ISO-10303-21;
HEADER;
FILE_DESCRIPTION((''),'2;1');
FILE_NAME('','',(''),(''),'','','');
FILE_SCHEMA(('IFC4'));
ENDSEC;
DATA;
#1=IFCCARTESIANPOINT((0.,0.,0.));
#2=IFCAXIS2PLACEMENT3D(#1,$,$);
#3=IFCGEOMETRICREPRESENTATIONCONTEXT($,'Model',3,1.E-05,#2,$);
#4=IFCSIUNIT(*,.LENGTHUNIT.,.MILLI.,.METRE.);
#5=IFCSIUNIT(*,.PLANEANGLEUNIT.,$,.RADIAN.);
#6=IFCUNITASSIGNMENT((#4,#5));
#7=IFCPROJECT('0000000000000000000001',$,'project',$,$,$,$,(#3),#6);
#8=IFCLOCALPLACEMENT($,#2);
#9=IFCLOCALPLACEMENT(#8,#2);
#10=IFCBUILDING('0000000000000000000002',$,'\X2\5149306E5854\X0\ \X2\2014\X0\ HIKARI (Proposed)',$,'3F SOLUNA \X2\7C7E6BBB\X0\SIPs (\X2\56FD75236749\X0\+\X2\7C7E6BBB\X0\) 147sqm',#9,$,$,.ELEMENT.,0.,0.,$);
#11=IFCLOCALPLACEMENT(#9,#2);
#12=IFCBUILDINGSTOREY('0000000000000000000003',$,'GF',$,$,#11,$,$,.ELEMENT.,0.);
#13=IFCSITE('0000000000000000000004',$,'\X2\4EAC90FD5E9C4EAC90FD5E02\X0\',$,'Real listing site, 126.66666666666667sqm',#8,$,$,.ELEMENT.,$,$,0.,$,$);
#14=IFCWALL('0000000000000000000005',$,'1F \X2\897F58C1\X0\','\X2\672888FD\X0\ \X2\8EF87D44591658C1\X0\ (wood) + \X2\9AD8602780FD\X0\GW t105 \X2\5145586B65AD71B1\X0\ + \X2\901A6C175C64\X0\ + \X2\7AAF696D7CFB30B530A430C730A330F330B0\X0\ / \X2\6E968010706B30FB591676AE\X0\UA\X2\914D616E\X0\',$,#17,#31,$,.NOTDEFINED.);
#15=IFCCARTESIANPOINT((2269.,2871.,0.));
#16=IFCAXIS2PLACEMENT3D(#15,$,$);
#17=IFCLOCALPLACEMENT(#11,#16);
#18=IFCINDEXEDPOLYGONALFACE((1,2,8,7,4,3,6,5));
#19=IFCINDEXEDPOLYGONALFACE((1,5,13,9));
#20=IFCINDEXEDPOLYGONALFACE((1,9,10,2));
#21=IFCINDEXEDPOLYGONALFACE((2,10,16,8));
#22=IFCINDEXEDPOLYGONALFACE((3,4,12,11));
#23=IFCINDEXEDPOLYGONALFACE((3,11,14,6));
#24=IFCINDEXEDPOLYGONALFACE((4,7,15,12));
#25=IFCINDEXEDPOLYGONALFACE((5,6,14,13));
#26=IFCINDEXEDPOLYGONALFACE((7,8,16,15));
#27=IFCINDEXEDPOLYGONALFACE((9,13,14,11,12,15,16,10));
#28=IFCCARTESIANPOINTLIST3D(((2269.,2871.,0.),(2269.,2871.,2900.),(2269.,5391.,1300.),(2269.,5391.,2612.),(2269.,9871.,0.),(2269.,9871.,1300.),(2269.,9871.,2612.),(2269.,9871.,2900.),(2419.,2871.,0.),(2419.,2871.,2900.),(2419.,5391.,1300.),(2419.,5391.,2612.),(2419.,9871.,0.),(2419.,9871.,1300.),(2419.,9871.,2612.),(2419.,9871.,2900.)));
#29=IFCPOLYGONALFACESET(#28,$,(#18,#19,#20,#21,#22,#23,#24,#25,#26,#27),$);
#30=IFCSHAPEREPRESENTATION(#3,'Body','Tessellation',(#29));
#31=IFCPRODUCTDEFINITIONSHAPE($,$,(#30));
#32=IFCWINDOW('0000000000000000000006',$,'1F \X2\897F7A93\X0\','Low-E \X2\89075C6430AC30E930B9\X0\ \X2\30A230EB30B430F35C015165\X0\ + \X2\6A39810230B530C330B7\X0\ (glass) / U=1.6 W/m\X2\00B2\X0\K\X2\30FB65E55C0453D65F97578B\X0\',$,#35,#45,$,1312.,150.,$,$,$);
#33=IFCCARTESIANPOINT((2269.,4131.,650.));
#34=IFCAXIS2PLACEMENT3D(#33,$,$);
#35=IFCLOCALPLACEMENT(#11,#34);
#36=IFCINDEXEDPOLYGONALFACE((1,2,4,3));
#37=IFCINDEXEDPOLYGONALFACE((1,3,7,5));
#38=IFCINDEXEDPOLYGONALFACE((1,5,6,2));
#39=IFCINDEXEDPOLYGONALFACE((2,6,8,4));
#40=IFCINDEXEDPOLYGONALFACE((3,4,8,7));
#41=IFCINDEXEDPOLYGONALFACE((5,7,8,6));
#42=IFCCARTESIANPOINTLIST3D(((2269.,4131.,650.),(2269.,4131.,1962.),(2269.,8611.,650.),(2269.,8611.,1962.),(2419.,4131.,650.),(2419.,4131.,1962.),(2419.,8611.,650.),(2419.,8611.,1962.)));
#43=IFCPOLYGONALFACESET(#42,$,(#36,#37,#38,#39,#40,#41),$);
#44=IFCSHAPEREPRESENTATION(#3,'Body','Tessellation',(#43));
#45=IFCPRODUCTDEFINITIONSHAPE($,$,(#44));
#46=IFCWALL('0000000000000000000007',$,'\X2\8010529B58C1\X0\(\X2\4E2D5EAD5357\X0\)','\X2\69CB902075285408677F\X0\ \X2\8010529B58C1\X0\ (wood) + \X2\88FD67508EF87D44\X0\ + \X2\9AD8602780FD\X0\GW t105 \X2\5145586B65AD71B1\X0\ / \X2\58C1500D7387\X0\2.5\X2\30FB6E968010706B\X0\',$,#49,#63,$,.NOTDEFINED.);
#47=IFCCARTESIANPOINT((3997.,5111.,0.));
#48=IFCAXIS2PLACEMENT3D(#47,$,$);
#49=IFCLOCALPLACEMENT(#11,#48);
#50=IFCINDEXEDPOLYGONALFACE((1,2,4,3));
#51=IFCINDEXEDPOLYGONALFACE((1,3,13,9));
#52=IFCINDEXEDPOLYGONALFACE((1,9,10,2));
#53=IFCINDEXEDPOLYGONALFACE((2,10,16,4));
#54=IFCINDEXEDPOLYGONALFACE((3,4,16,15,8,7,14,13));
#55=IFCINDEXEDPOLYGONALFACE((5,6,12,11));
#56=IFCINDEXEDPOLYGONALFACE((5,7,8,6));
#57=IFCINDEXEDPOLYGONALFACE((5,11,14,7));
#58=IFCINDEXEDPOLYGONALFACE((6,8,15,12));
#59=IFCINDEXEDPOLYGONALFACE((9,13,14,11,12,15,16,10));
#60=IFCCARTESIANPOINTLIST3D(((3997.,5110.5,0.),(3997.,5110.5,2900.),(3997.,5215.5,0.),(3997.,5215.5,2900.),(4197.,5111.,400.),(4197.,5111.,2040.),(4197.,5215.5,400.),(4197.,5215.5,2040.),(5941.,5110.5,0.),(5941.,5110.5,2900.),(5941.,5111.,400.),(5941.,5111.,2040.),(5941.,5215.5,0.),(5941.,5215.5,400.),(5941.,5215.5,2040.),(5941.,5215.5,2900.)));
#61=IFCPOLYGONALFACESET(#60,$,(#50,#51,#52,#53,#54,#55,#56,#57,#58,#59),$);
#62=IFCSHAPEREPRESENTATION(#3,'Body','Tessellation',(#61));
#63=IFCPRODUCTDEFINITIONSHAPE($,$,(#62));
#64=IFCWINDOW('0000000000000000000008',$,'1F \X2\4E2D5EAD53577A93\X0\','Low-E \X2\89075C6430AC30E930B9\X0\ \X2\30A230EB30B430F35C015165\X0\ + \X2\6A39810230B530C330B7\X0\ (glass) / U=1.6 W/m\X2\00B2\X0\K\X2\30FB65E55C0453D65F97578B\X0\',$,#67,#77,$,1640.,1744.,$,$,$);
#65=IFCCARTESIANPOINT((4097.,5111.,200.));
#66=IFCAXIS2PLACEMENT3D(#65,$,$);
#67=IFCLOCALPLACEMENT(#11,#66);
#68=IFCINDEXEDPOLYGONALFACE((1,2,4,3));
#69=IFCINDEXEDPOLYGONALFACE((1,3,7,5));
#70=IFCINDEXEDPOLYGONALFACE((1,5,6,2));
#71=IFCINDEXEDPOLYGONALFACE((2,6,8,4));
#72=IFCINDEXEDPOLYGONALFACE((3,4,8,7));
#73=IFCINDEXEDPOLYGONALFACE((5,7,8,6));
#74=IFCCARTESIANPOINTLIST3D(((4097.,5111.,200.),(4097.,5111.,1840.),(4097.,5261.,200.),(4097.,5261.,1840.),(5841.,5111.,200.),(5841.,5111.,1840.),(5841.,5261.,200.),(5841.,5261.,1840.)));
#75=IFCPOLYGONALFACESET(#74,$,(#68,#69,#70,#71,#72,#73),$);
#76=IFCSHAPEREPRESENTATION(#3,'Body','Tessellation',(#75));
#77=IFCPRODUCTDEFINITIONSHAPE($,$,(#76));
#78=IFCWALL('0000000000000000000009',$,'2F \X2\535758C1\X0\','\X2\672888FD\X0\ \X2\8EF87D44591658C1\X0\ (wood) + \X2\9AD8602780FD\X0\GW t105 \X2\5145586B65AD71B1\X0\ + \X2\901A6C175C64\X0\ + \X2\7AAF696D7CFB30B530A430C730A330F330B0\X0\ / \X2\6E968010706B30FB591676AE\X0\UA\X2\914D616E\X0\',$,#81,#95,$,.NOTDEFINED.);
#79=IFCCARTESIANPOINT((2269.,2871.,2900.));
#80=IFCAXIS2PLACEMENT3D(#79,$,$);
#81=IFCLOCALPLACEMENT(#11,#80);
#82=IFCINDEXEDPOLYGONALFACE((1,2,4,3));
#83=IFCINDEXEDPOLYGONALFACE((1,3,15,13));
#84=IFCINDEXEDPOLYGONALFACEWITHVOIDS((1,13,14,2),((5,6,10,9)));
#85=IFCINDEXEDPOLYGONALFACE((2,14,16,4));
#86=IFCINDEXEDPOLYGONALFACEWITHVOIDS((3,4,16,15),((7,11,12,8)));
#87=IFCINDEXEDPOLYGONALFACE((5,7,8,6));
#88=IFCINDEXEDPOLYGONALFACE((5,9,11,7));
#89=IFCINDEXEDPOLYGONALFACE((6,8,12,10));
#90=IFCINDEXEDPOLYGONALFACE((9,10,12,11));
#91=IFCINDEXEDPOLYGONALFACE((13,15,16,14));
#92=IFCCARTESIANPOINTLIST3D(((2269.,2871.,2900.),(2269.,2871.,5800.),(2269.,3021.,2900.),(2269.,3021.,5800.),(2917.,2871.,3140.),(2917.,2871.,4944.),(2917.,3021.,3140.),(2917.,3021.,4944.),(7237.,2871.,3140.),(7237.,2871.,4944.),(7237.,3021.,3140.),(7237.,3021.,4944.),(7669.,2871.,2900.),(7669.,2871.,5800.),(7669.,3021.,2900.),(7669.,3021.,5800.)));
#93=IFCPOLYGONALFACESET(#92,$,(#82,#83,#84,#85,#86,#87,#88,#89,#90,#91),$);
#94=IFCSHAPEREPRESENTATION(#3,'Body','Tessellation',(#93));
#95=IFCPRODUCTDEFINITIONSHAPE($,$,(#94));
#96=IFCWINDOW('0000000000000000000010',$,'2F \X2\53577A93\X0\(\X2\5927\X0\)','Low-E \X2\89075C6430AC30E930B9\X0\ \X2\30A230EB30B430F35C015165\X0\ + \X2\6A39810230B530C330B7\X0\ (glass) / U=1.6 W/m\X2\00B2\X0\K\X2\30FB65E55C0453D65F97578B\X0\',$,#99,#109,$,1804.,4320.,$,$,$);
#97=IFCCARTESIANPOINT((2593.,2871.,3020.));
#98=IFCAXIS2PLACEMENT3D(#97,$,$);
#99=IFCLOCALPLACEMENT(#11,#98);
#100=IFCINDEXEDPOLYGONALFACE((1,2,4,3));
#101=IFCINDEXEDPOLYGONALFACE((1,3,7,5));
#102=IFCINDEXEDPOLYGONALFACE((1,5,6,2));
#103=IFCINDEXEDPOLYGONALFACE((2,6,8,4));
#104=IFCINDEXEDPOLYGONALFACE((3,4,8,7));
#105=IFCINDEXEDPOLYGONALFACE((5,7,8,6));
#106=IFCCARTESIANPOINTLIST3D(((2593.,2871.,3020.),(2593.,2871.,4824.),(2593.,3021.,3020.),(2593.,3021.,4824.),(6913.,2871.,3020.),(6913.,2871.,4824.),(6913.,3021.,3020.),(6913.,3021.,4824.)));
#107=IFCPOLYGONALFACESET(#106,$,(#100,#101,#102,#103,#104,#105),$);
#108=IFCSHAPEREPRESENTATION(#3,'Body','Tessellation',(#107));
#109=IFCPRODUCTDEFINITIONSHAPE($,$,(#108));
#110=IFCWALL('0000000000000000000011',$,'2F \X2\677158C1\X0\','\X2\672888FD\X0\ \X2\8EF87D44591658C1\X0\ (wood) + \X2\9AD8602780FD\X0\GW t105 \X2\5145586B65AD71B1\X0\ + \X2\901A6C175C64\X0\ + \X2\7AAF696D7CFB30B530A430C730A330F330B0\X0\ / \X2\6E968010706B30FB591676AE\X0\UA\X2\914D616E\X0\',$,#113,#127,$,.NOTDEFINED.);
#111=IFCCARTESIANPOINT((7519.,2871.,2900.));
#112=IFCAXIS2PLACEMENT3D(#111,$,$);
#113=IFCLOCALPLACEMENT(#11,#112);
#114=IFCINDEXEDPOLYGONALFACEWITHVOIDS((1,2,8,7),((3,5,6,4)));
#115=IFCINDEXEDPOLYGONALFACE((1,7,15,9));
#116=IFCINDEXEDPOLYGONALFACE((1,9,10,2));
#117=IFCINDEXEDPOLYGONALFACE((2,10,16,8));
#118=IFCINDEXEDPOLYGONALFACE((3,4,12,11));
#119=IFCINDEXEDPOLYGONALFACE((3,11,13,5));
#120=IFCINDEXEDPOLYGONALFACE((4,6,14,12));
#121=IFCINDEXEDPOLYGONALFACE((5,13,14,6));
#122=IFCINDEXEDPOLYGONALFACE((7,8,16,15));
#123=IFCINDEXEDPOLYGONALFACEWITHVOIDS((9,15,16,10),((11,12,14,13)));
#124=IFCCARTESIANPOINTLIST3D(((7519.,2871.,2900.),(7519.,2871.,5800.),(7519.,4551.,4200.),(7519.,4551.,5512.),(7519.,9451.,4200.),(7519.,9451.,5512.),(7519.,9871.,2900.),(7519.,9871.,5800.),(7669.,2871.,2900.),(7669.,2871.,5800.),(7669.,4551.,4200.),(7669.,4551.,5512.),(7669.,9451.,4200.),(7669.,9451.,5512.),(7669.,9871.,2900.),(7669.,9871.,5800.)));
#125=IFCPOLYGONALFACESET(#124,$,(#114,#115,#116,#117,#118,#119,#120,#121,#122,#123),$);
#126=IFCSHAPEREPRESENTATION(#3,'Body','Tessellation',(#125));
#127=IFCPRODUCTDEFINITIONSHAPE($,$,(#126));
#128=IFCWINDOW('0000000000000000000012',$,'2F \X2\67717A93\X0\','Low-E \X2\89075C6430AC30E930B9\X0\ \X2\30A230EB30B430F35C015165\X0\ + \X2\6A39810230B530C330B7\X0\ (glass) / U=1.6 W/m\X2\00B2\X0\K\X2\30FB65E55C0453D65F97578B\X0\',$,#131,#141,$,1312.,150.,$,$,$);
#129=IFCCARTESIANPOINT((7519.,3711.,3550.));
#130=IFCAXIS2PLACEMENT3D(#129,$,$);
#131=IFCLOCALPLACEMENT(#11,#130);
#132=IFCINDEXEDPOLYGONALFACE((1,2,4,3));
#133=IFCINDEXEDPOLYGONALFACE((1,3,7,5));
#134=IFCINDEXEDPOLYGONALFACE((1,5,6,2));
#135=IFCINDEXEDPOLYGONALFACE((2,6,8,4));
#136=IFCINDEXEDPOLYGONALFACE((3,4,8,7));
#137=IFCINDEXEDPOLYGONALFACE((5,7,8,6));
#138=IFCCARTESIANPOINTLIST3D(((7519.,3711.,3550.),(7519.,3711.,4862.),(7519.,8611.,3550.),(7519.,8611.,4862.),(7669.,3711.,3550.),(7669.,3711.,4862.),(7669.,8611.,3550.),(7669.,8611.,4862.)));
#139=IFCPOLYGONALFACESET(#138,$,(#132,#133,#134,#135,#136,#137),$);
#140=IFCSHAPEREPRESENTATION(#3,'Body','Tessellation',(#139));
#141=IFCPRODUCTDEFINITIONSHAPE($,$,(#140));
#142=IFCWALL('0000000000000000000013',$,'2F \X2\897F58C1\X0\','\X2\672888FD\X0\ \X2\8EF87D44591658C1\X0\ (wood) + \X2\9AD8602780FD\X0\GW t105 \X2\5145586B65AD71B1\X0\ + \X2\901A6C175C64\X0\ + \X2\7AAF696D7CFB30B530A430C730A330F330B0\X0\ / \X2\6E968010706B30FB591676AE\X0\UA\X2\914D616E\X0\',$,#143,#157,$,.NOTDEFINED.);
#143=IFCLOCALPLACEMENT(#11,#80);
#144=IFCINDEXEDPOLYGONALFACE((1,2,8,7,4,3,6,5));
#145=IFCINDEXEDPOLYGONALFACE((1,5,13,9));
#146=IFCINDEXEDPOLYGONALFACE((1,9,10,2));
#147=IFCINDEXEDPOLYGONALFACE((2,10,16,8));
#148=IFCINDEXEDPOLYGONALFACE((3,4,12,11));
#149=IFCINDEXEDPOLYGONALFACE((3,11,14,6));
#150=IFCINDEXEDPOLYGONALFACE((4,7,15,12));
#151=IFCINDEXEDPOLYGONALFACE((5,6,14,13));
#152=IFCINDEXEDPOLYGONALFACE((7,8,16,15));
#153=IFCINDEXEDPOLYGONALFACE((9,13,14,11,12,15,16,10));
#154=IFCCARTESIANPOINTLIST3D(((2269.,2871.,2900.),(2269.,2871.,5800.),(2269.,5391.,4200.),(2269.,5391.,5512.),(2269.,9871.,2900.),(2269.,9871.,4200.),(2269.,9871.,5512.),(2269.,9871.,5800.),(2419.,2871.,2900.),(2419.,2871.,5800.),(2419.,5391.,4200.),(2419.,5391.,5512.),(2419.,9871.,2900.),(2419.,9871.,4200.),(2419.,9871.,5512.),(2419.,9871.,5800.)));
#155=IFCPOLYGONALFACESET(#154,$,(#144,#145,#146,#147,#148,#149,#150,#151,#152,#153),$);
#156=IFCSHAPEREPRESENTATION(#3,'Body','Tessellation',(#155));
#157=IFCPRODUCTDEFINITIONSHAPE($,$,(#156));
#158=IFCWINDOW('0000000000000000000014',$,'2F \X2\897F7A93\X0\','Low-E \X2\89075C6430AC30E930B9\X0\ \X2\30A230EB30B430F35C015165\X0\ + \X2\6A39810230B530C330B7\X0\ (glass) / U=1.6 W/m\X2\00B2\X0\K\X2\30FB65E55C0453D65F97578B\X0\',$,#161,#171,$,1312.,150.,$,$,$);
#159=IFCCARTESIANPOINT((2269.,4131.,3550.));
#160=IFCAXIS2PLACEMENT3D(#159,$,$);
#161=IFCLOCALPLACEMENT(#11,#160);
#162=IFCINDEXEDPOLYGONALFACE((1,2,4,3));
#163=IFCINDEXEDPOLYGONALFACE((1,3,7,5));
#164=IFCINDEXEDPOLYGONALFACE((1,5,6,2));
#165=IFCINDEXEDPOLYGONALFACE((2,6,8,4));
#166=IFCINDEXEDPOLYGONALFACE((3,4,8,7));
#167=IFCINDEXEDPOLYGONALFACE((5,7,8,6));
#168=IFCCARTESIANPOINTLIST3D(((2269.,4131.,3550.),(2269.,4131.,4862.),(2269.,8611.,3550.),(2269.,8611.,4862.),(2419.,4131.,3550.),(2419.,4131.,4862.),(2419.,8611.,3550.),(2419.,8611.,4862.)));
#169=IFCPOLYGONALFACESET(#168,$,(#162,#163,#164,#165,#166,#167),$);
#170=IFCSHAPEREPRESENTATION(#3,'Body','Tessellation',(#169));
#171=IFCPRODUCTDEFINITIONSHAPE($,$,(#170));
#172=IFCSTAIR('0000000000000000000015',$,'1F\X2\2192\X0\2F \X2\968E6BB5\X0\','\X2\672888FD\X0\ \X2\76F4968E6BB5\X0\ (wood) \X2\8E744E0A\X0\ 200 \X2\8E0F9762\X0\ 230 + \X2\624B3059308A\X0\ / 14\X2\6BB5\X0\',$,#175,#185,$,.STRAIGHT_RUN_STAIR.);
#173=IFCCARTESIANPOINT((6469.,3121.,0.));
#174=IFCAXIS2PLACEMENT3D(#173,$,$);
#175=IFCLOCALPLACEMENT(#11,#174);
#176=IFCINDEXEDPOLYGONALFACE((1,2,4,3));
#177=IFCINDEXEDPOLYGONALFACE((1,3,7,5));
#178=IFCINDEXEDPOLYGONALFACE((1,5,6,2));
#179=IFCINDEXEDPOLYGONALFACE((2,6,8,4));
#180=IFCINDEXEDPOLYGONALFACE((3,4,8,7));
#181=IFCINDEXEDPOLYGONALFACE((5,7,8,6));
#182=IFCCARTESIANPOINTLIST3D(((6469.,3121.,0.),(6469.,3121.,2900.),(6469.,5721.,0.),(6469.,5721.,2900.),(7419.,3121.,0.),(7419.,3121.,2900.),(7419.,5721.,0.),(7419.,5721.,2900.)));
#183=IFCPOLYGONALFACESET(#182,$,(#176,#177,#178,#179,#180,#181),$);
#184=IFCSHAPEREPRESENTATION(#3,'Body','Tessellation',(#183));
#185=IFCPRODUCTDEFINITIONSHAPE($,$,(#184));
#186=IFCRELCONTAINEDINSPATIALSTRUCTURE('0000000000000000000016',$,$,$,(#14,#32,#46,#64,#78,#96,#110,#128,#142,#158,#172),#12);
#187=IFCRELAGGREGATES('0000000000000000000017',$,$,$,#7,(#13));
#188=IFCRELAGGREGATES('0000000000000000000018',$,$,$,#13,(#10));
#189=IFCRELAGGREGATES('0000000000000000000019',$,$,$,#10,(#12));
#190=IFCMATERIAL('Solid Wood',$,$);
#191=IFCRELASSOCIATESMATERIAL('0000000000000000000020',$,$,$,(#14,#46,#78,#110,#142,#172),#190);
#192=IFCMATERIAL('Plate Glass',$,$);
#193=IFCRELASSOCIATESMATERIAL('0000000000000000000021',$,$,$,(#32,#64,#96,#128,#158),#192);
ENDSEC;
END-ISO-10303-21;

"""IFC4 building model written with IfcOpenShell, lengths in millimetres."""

from ifc_helpers import new_model, si_unit, frame, frame_2d, origin, place, context, project, spatial, rectangle, extrude, material, element, fill, save


model = new_model("IFC4")

# Units and contexts
model_context = context("Model", 3, precision=1e-05, world=origin())
ifc_project = project(units=[si_unit("LENGTHUNIT", "METRE", prefix="MILLI"), si_unit("PLANEANGLEUNIT", "RADIAN")], contexts=[model_context])

# Site, building, storey
site_placement = place(None, origin())
site = spatial("IfcSite", under=ifc_project, at=site_placement, Name="京都府京都市", ObjectType="Real listing site, 126.66666666666667sqm", CompositionType="ELEMENT", RefElevation=0.0)
building_placement = place(site_placement, origin())
building = spatial("IfcBuilding", under=site, at=building_placement, Name="光の塔 — HIKARI (Proposed)", ObjectType="3F SOLUNA 籾殻SIPs (国産杉+籾殻) 147sqm", CompositionType="ELEMENT", ElevationOfRefHeight=0.0, ElevationOfTerrain=0.0)
storey_placement = place(building_placement, origin())
storey = spatial("IfcBuildingStorey", under=building, at=storey_placement, Name="GF", CompositionType="ELEMENT", Elevation=0.0)

# Shared definitions
ifc_material_1 = material(Name="Solid Wood")

# Shared definitions
ifc_material_2 = material(Name="Plate Glass")

# Walls, openings, windows
wall_1_placement = place(storey_placement, frame((2269.0, 2871.0, 0.0)))
wall_1 = element("IfcWall", 1, at=wall_1_placement, inside=storey, material=ifc_material_1, Name="1F 西壁", Description="木製 軸組外壁 (wood) + 高性能GW t105 充填断熱 + 通気層 + 窯業系サイディング / 準耐火・外皮UA配慮", PredefinedType="NOTDEFINED", context=model_context, shape_type="SweptSolid", body=[
    extrude(rectangle(XDim=150.0, YDim=7000.0, at=frame_2d((75.0, 3500.0))), frame((2269.0, 2871.0, 0.0)), (0.0, 0.0, 1.0), 2900.0),
])
opening_1_placement = place(storey_placement, frame((2269.0, 4131.0, 650.0)))
opening_1 = element("IfcOpeningElement", 2, at=opening_1_placement, cuts=wall_1, PredefinedType="NOTDEFINED", context=model_context, shape_type="SweptSolid", body=[
    extrude(rectangle(XDim=150.0, YDim=4480.0, at=frame_2d((75.0, 2240.0))), frame((2269.0, 4131.0, 650.0)), (0.0, 0.0, 1.0), 1312.0),
])
window_1_placement = place(storey_placement, frame((2269.0, 4131.0, 650.0)))
window_1 = element("IfcWindow", 3, at=window_1_placement, inside=storey, material=ifc_material_2, Name="1F 西窓", Description="Low-E 複層ガラス アルゴン封入 + 樹脂サッシ (glass) / U=1.6 W/m²K・日射取得型", OverallHeight=1312.0, OverallWidth=150.0, context=model_context, shape_type="SweptSolid", body=[
    extrude(rectangle(XDim=150.0, YDim=4480.0, at=frame_2d((75.0, 2240.0))), frame((2269.0, 4131.0, 650.0)), (0.0, 0.0, 1.0), 1312.0),
])
fill(opening_1, window_1)
wall_2_placement = place(storey_placement, frame((3997.0, 5111.0, 0.0)))
wall_2 = element("IfcWall", 4, at=wall_2_placement, inside=storey, material=ifc_material_1, Name="耐力壁(中庭南)", Description="構造用合板 耐力壁 (wood) + 製材軸組 + 高性能GW t105 充填断熱 / 壁倍率2.5・準耐火", PredefinedType="NOTDEFINED", context=model_context, shape_type="SweptSolid", body=[
    extrude(rectangle(XDim=1944.0, YDim=105.0, at=frame_2d((972.0, 52.0))), frame((3997.0, 5111.0, 0.0)), (0.0, 0.0, 1.0), 2900.0),
])
opening_2_placement = place(storey_placement, frame((4097.0, 5111.0, 200.0)))
opening_2 = element("IfcOpeningElement", 5, at=opening_2_placement, cuts=wall_2, PredefinedType="NOTDEFINED", context=model_context, shape_type="SweptSolid", body=[
    extrude(rectangle(XDim=1744.0, YDim=150.0, at=frame_2d((872.0, 75.0))), frame((4097.0, 5111.0, 200.0)), (0.0, 0.0, 1.0), 1640.0),
])
window_2_placement = place(storey_placement, frame((4097.0, 5111.0, 200.0)))
window_2 = element("IfcWindow", 6, at=window_2_placement, inside=storey, material=ifc_material_2, Name="1F 中庭南窓", Description="Low-E 複層ガラス アルゴン封入 + 樹脂サッシ (glass) / U=1.6 W/m²K・日射取得型", OverallHeight=1640.0, OverallWidth=1744.0, context=model_context, shape_type="SweptSolid", body=[
    extrude(rectangle(XDim=1744.0, YDim=150.0, at=frame_2d((872.0, 75.0))), frame((4097.0, 5111.0, 200.0)), (0.0, 0.0, 1.0), 1640.0),
])
fill(opening_2, window_2)
wall_3_placement = place(storey_placement, frame((2269.0, 2871.0, 2900.0)))
wall_3 = element("IfcWall", 7, at=wall_3_placement, inside=storey, material=ifc_material_1, Name="2F 南壁", Description="木製 軸組外壁 (wood) + 高性能GW t105 充填断熱 + 通気層 + 窯業系サイディング / 準耐火・外皮UA配慮", PredefinedType="NOTDEFINED", context=model_context, shape_type="SweptSolid", body=[
    extrude(rectangle(XDim=5400.0, YDim=150.0, at=frame_2d((2700.0, 75.0))), frame((2269.0, 2871.0, 2900.0)), (0.0, 0.0, 1.0), 2900.0),
])
opening_3_placement = place(storey_placement, frame((2593.0, 2871.0, 3020.0)))
opening_3 = element("IfcOpeningElement", 8, at=opening_3_placement, cuts=wall_3, PredefinedType="NOTDEFINED", context=model_context, shape_type="SweptSolid", body=[
    extrude(rectangle(XDim=4320.0, YDim=150.0, at=frame_2d((2160.0, 75.0))), frame((2593.0, 2871.0, 3020.0)), (0.0, 0.0, 1.0), 1804.0),
])
window_3_placement = place(storey_placement, frame((2593.0, 2871.0, 3020.0)))
window_3 = element("IfcWindow", 9, at=window_3_placement, inside=storey, material=ifc_material_2, Name="2F 南窓(大)", Description="Low-E 複層ガラス アルゴン封入 + 樹脂サッシ (glass) / U=1.6 W/m²K・日射取得型", OverallHeight=1804.0, OverallWidth=4320.0, context=model_context, shape_type="SweptSolid", body=[
    extrude(rectangle(XDim=4320.0, YDim=150.0, at=frame_2d((2160.0, 75.0))), frame((2593.0, 2871.0, 3020.0)), (0.0, 0.0, 1.0), 1804.0),
])
fill(opening_3, window_3)
wall_4_placement = place(storey_placement, frame((7519.0, 2871.0, 2900.0)))
wall_4 = element("IfcWall", 10, at=wall_4_placement, inside=storey, material=ifc_material_1, Name="2F 東壁", Description="木製 軸組外壁 (wood) + 高性能GW t105 充填断熱 + 通気層 + 窯業系サイディング / 準耐火・外皮UA配慮", PredefinedType="NOTDEFINED", context=model_context, shape_type="SweptSolid", body=[
    extrude(rectangle(XDim=150.0, YDim=7000.0, at=frame_2d((75.0, 3500.0))), frame((7519.0, 2871.0, 2900.0)), (0.0, 0.0, 1.0), 2900.0),
])
opening_4_placement = place(storey_placement, frame((7519.0, 3711.0, 3550.0)))
opening_4 = element("IfcOpeningElement", 11, at=opening_4_placement, cuts=wall_4, PredefinedType="NOTDEFINED", context=model_context, shape_type="SweptSolid", body=[
    extrude(rectangle(XDim=150.0, YDim=4900.0, at=frame_2d((75.0, 2450.0))), frame((7519.0, 3711.0, 3550.0)), (0.0, 0.0, 1.0), 1312.0),
])
window_4_placement = place(storey_placement, frame((7519.0, 3711.0, 3550.0)))
window_4 = element("IfcWindow", 12, at=window_4_placement, inside=storey, material=ifc_material_2, Name="2F 東窓", Description="Low-E 複層ガラス アルゴン封入 + 樹脂サッシ (glass) / U=1.6 W/m²K・日射取得型", OverallHeight=1312.0, OverallWidth=150.0, context=model_context, shape_type="SweptSolid", body=[
    extrude(rectangle(XDim=150.0, YDim=4900.0, at=frame_2d((75.0, 2450.0))), frame((7519.0, 3711.0, 3550.0)), (0.0, 0.0, 1.0), 1312.0),
])
fill(opening_4, window_4)
wall_5_placement = place(storey_placement, frame((2269.0, 2871.0, 2900.0)))
wall_5 = element("IfcWall", 13, at=wall_5_placement, inside=storey, material=ifc_material_1, Name="2F 西壁", Description="木製 軸組外壁 (wood) + 高性能GW t105 充填断熱 + 通気層 + 窯業系サイディング / 準耐火・外皮UA配慮", PredefinedType="NOTDEFINED", context=model_context, shape_type="SweptSolid", body=[
    extrude(rectangle(XDim=150.0, YDim=7000.0, at=frame_2d((75.0, 3500.0))), frame((2269.0, 2871.0, 2900.0)), (0.0, 0.0, 1.0), 2900.0),
])
opening_5_placement = place(storey_placement, frame((2269.0, 4131.0, 3550.0)))
opening_5 = element("IfcOpeningElement", 14, at=opening_5_placement, cuts=wall_5, PredefinedType="NOTDEFINED", context=model_context, shape_type="SweptSolid", body=[
    extrude(rectangle(XDim=150.0, YDim=4480.0, at=frame_2d((75.0, 2240.0))), frame((2269.0, 4131.0, 3550.0)), (0.0, 0.0, 1.0), 1312.0),
])
window_5_placement = place(storey_placement, frame((2269.0, 4131.0, 3550.0)))
window_5 = element("IfcWindow", 15, at=window_5_placement, inside=storey, material=ifc_material_2, Name="2F 西窓", Description="Low-E 複層ガラス アルゴン封入 + 樹脂サッシ (glass) / U=1.6 W/m²K・日射取得型", OverallHeight=1312.0, OverallWidth=150.0, context=model_context, shape_type="SweptSolid", body=[
    extrude(rectangle(XDim=150.0, YDim=4480.0, at=frame_2d((75.0, 2240.0))), frame((2269.0, 4131.0, 3550.0)), (0.0, 0.0, 1.0), 1312.0),
])
fill(opening_5, window_5)

# Stair
stair_1_placement = place(storey_placement, frame((6469.0, 3121.0, 0.0)))
element("IfcStair", 16, at=stair_1_placement, inside=storey, material=ifc_material_1, Name="1F→2F 階段", Description="木製 直階段 (wood) 蹴上 200 踏面 230 + 手すり / 14段", PredefinedType="STRAIGHT_RUN_STAIR", context=model_context, shape_type="SweptSolid", body=[
    extrude(rectangle(XDim=950.0, YDim=2600.0, at=frame_2d((475.0, 1300.0))), frame((6469.0, 3121.0, 0.0)), (0.0, 0.0, 1.0), 2900.0),
])

save(model, "model.ifc")
